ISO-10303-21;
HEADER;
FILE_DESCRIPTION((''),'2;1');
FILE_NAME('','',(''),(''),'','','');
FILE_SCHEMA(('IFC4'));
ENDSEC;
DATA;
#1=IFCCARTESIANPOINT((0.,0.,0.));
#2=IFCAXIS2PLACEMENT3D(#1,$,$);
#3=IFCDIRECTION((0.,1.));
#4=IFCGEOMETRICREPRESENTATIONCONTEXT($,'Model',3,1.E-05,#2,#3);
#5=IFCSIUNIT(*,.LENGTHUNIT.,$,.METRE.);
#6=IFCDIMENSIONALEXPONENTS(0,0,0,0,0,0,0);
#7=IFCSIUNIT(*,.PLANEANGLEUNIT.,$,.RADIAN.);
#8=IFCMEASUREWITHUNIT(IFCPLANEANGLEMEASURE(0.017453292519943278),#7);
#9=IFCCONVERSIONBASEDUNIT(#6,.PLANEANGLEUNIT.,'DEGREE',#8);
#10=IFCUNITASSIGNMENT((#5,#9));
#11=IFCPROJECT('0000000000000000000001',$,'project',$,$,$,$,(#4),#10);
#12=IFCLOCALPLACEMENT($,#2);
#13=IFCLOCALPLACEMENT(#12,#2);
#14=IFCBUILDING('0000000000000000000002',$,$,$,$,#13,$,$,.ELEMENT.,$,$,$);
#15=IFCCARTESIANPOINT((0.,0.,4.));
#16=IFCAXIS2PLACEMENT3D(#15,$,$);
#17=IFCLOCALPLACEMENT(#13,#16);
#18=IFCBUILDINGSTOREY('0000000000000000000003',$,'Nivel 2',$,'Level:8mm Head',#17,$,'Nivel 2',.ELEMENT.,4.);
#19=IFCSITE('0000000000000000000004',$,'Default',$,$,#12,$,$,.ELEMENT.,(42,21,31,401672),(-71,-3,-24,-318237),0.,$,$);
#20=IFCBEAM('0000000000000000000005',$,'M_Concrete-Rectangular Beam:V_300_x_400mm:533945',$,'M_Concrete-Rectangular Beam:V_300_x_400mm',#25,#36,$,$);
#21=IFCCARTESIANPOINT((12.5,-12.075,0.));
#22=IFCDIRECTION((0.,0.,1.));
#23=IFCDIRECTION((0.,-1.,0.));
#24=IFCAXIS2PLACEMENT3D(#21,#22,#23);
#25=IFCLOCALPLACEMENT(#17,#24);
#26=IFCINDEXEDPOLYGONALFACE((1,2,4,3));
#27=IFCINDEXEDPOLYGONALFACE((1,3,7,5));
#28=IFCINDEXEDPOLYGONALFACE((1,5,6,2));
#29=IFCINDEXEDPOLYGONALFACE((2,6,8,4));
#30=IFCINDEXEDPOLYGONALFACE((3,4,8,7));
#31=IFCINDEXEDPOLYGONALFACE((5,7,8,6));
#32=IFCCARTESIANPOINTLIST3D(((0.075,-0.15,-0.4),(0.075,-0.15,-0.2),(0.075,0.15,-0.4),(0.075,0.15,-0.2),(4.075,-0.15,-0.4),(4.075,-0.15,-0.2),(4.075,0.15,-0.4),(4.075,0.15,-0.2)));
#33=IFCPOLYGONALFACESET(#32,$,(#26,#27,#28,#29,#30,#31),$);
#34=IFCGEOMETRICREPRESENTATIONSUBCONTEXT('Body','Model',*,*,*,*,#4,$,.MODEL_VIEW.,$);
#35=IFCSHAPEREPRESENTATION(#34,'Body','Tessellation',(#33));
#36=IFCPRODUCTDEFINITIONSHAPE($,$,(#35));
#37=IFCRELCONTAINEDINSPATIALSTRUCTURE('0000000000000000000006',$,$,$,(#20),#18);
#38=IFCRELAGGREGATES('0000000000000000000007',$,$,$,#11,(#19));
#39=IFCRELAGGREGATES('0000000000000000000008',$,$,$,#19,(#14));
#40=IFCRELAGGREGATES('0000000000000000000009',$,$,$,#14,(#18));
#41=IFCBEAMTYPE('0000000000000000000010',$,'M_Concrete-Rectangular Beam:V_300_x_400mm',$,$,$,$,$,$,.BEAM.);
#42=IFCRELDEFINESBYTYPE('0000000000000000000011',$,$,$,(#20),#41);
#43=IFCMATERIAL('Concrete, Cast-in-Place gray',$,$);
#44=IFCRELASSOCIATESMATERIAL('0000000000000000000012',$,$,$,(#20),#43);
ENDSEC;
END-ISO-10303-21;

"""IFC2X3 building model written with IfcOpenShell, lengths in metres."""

from ifc_helpers import new_model, entity, si_unit, converted_unit, direction, frame, frame_2d, origin, place, context, subcontext, project, spatial, rectangle, extrude, material, type_object, element, save


model = new_model("IFC2X3")

# Units and contexts
model_context = context("Model", 3, precision=1e-05, world=origin(), true_north=direction((0.0, 1.0)))
body_context = subcontext(model_context, "Body", "Model", "MODEL_VIEW")
ifc_project = project(units=[si_unit("LENGTHUNIT", "METRE"), converted_unit("PLANEANGLEUNIT", "DEGREE", entity("IfcPlaneAngleMeasure", 0.017453292519943278), si_unit("PLANEANGLEUNIT", "RADIAN"), dimensions=[0, 0, 0, 0, 0, 0, 0])], contexts=[model_context])

# Site, building, storey
site_placement = place(None, origin())
site = spatial("IfcSite", under=ifc_project, at=site_placement, Name="Default", CompositionType="ELEMENT", RefLatitude=(42, 21, 31, 401672), RefLongitude=(-71, -3, -24, -318237), RefElevation=0.0)
building_placement = place(site_placement, origin())
building = spatial("IfcBuilding", under=site, at=building_placement, CompositionType="ELEMENT")
storey_placement = place(building_placement, frame((0.0, 0.0, 4.0)))
storey = spatial("IfcBuildingStorey", under=building, at=storey_placement, Name="Nivel 2", ObjectType="Level:8mm Head", LongName="Nivel 2", CompositionType="ELEMENT", Elevation=4.0)

# Beam
ifc_material_1 = material(Name="Concrete, Cast-in-Place gray")
beam_type_1 = type_object("IfcBeamType", Name="M_Concrete-Rectangular Beam:V_300_x_400mm", PredefinedType="BEAM")
beam_1_placement = place(storey_placement, frame((12.5, -12.075, 0.0), z_axis=(0.0, 0.0, 1.0), x_axis=(0.0, -1.0, 0.0)))
element("IfcBeam", 1, at=beam_1_placement, inside=storey, type_object=beam_type_1, material=ifc_material_1, Name="M_Concrete-Rectangular Beam:V_300_x_400mm:533945", ObjectType="M_Concrete-Rectangular Beam:V_300_x_400mm", context=body_context, shape_type="SweptSolid", body=[
    extrude(rectangle(XDim=0.2, YDim=0.3, at=frame_2d((0.0, 0.0), x_axis=(1.0, 0.0))), frame((0.075, 0.0, -0.3), z_axis=(1.0, 0.0, 0.0), x_axis=(0.0, 0.0, -1.0)), (0.0, 0.0, 1.0), 4.0),
])

save(model, "model.ifc")
